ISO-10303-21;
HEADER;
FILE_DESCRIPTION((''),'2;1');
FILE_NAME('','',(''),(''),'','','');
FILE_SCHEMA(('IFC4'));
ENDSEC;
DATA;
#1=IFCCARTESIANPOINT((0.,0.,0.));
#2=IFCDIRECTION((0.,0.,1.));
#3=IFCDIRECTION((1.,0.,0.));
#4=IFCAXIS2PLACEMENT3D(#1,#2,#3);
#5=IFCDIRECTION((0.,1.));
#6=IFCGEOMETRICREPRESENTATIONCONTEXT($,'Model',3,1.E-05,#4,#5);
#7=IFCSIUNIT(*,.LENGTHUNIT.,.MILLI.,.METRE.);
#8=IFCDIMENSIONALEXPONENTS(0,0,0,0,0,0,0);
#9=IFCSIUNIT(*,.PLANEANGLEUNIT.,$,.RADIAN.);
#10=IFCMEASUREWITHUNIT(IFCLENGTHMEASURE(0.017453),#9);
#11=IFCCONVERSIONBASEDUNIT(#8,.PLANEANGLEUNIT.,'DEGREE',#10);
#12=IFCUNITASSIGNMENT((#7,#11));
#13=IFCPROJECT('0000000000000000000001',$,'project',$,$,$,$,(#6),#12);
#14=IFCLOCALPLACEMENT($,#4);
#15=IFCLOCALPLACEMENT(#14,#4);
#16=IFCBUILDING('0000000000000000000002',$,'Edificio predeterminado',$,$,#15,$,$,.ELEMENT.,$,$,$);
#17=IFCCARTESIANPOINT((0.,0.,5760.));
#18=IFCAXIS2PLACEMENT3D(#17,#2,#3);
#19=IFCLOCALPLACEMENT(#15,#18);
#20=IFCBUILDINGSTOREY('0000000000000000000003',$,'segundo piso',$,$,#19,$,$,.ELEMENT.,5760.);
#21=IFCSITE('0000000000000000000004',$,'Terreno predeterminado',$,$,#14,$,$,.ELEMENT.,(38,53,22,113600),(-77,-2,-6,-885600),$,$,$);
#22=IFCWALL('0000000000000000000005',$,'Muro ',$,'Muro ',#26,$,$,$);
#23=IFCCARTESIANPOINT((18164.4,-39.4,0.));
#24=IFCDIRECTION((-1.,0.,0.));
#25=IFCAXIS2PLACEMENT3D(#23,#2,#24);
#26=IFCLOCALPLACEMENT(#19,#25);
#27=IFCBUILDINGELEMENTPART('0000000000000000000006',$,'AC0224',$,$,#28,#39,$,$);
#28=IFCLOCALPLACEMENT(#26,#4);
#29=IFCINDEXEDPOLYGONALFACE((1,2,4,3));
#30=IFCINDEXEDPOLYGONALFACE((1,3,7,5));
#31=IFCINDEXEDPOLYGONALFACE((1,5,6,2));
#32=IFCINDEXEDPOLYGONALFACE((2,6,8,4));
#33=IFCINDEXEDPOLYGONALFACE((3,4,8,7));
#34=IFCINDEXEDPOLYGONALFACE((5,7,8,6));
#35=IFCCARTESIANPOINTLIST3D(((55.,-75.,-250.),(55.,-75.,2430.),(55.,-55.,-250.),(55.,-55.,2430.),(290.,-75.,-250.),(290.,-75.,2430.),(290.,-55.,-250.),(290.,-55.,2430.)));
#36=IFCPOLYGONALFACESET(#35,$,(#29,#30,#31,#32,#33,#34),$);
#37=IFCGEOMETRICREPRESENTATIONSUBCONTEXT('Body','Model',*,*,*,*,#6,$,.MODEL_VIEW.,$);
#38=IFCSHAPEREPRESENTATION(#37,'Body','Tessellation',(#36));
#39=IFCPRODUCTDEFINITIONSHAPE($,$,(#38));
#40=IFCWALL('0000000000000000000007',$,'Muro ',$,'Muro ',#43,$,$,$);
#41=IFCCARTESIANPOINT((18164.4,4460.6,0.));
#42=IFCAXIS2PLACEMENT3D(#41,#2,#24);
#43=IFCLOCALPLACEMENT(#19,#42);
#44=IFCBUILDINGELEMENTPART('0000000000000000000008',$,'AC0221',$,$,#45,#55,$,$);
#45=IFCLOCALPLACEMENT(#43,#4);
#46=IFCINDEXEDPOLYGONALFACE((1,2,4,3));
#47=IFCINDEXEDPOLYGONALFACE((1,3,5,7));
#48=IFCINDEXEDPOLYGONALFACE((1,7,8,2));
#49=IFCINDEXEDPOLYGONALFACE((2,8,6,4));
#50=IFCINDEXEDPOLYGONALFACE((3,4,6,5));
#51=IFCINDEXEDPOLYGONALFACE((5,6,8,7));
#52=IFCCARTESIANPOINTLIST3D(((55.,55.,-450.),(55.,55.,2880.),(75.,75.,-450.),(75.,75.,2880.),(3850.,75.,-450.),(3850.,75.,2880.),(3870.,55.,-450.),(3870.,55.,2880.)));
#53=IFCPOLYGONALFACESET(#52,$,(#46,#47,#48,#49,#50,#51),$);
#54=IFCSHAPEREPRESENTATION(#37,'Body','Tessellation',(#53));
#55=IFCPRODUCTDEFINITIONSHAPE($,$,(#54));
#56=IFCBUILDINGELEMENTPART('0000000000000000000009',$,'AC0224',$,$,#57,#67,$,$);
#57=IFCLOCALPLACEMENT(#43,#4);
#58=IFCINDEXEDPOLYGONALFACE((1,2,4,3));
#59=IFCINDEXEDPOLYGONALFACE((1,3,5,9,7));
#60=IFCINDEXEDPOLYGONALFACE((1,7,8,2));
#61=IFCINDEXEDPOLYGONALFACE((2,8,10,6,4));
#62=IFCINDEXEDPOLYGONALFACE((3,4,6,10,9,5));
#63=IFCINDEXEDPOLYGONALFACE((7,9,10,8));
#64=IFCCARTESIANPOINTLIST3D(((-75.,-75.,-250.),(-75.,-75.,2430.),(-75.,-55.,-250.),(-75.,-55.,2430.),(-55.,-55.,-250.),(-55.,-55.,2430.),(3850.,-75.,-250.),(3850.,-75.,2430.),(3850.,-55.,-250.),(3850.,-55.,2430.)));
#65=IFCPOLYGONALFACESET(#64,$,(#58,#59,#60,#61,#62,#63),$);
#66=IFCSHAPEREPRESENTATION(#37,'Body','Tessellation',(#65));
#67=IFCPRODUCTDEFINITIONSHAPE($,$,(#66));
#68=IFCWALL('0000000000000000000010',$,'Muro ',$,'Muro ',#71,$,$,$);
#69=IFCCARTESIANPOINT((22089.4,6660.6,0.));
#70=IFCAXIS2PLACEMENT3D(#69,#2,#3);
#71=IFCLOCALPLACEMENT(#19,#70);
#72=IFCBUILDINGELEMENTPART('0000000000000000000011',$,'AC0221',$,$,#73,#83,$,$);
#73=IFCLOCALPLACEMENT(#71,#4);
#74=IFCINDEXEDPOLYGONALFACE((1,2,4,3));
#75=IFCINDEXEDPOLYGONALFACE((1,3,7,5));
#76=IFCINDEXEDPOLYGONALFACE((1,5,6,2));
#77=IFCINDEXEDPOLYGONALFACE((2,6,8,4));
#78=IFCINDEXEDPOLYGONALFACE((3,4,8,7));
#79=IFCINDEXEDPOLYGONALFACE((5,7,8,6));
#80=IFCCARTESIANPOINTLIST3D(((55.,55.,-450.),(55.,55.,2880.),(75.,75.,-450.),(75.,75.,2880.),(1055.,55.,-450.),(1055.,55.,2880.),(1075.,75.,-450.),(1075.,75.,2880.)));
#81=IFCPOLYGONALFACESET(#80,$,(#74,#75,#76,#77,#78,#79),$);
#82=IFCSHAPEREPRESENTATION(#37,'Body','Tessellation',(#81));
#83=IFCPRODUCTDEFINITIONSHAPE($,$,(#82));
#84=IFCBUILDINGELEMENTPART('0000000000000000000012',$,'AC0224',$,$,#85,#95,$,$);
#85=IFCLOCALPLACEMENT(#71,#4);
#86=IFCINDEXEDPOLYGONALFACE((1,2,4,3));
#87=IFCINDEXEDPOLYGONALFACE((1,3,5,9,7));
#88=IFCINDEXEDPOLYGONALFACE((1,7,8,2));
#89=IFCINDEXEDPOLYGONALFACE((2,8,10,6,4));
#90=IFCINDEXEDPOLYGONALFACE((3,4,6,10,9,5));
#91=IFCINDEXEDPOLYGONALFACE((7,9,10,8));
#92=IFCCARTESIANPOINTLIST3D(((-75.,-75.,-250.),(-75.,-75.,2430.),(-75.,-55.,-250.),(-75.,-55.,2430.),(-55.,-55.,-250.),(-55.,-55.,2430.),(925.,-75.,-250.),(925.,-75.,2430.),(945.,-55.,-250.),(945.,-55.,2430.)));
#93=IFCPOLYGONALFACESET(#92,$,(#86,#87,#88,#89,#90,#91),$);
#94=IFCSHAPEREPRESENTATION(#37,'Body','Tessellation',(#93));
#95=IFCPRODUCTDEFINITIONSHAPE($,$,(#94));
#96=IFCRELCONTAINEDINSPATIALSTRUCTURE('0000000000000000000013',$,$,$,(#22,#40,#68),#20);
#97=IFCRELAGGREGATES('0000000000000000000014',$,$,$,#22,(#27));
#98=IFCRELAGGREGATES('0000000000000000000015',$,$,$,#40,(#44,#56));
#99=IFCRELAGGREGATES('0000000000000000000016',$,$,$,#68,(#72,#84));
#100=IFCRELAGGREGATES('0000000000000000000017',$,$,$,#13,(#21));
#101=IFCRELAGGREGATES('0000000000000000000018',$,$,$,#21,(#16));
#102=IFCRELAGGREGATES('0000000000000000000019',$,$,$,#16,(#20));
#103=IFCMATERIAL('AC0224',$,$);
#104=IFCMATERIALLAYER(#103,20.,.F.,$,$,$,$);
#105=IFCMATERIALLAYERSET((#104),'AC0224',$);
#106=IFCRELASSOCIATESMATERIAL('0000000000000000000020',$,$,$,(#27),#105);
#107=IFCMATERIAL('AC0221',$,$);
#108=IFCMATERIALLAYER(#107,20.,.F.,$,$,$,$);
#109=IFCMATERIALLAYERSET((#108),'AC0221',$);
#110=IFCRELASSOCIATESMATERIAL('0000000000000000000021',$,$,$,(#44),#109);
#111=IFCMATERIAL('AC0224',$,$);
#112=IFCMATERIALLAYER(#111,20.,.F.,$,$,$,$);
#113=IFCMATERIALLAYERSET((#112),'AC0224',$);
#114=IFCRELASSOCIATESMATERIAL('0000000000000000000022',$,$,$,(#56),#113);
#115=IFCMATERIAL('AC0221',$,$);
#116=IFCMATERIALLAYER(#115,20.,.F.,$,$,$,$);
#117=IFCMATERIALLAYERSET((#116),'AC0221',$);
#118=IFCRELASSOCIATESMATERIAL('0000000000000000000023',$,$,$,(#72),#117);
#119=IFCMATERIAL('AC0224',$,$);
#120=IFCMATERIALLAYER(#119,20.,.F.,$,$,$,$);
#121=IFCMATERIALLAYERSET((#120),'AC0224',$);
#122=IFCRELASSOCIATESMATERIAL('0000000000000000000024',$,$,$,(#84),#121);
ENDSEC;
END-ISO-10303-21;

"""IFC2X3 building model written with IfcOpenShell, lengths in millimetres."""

from ifc_helpers import new_model, entity, si_unit, converted_unit, direction, frame, origin_with_axes, place, context, subcontext, project, spatial, polyline, outline, extrude, material, layer, layer_set, layer_usage, element, aggregate, save


model = new_model("IFC2X3")

# Units and contexts
model_context = context("Model", 3, precision=1e-05, world=origin_with_axes(), true_north=direction((0.0, 1.0)))
body_context = subcontext(model_context, "Body", "Model", "MODEL_VIEW")
ifc_project = project(units=[si_unit("LENGTHUNIT", "METRE", prefix="MILLI"), converted_unit("PLANEANGLEUNIT", "DEGREE", entity("IfcLengthMeasure", 0.017453), si_unit("PLANEANGLEUNIT", "RADIAN"), dimensions=[0, 0, 0, 0, 0, 0, 0])], contexts=[model_context])

# Site, building, storey
site_placement = place(None, origin_with_axes())
site = spatial("IfcSite", under=ifc_project, at=site_placement, Name="Terreno predeterminado", CompositionType="ELEMENT", RefLatitude=(38, 53, 22, 113600), RefLongitude=(-77, -2, -6, -885600))
building_placement = place(site_placement, origin_with_axes())
building = spatial("IfcBuilding", under=site, at=building_placement, Name="Edificio predeterminado", CompositionType="ELEMENT")
storey_placement = place(building_placement, frame((0.0, 0.0, 5760.0), z_axis=(0.0, 0.0, 1.0), x_axis=(1.0, 0.0, 0.0)))
storey = spatial("IfcBuildingStorey", under=building, at=storey_placement, Name="segundo piso", CompositionType="ELEMENT", Elevation=5760.0)

# Wall, building element part
wall_1_placement = place(storey_placement, frame((18164.4, -39.4, 0.0), z_axis=(0.0, 0.0, 1.0), x_axis=(-1.0, 0.0, 0.0)))
wall_1 = element("IfcWall", 1, at=wall_1_placement, inside=storey, Name="Muro ", ObjectType="Muro ")
ifc_material_1 = material(Name="AC0224")
ifc_layer_1 = layer(ifc_material_1, 20.0, ventilated=False)
ifc_layer_set_1 = layer_set([ifc_layer_1], Name="AC0224")
ifc_layer_usage_1 = layer_usage(ifc_layer_set_1, "AXIS2", "NEGATIVE", 55.0)
building_element_part_1_placement = place(wall_1_placement, origin_with_axes())
building_element_part_1 = element("IfcBuildingElementPart", 2, at=building_element_part_1_placement, material=ifc_layer_usage_1, Name="AC0224", context=body_context, shape_type="SweptSolid", body=[
    extrude(outline(polyline([(290.0, -55.0), (290.0, -75.0), (55.0, -75.0), (55.0, -55.0), (290.0, -55.0)])), frame((0.0, 0.0, -250.0), z_axis=(0.0, 0.0, 1.0), x_axis=(1.0, 0.0, 0.0)), (0.0, 0.0, 1.0), 2680.0),
])
aggregate(wall_1, [building_element_part_1])

# Walls, building element parts
wall_2_placement = place(storey_placement, frame((18164.4, 4460.6, 0.0), z_axis=(0.0, 0.0, 1.0), x_axis=(-1.0, 0.0, 0.0)))
wall_2 = element("IfcWall", 3, at=wall_2_placement, inside=storey, Name="Muro ", ObjectType="Muro ")
ifc_material_2 = material(Name="AC0221")
ifc_layer_2 = layer(ifc_material_2, 20.0, ventilated=False)
ifc_layer_set_2 = layer_set([ifc_layer_2], Name="AC0221")
ifc_layer_usage_2 = layer_usage(ifc_layer_set_2, "AXIS2", "NEGATIVE", -75.0)
building_element_part_2_placement = place(wall_2_placement, origin_with_axes())
building_element_part_2 = element("IfcBuildingElementPart", 4, at=building_element_part_2_placement, material=ifc_layer_usage_2, Name="AC0221", context=body_context, shape_type="SweptSolid", body=[
    extrude(outline(polyline([(3850.0, 75.0), (3870.0, 55.0), (55.0, 55.0), (75.0, 75.0), (3850.0, 75.0)])), frame((0.0, 0.0, -450.0), z_axis=(0.0, 0.0, 1.0), x_axis=(1.0, 0.0, 0.0)), (0.0, 0.0, 1.0), 3330.0),
])
ifc_material_3 = material(Name="AC0224")
ifc_layer_3 = layer(ifc_material_3, 20.0, ventilated=False)
ifc_layer_set_3 = layer_set([ifc_layer_3], Name="AC0224")
ifc_layer_usage_3 = layer_usage(ifc_layer_set_3, "AXIS2", "NEGATIVE", 55.0)
building_element_part_3_placement = place(wall_2_placement, origin_with_axes())
building_element_part_3 = element("IfcBuildingElementPart", 5, at=building_element_part_3_placement, material=ifc_layer_usage_3, Name="AC0224", context=body_context, shape_type="SweptSolid", body=[
    extrude(outline(polyline([(3850.0, -55.0), (3850.0, -75.0), (-75.0, -75.0), (-75.0, -55.0), (-55.0, -55.0), (3850.0, -55.0)])), frame((0.0, 0.0, -250.0), z_axis=(0.0, 0.0, 1.0), x_axis=(1.0, 0.0, 0.0)), (0.0, 0.0, 1.0), 2680.0),
])
aggregate(wall_2, [building_element_part_2, building_element_part_3])
wall_3_placement = place(storey_placement, frame((22089.4, 6660.6, 0.0), z_axis=(0.0, 0.0, 1.0), x_axis=(1.0, 0.0, 0.0)))
wall_3 = element("IfcWall", 6, at=wall_3_placement, inside=storey, Name="Muro ", ObjectType="Muro ")
ifc_material_4 = material(Name="AC0221")
ifc_layer_4 = layer(ifc_material_4, 20.0, ventilated=False)
ifc_layer_set_4 = layer_set([ifc_layer_4], Name="AC0221")
ifc_layer_usage_4 = layer_usage(ifc_layer_set_4, "AXIS2", "NEGATIVE", -75.0)
building_element_part_4_placement = place(wall_3_placement, origin_with_axes())
building_element_part_4 = element("IfcBuildingElementPart", 7, at=building_element_part_4_placement, material=ifc_layer_usage_4, Name="AC0221", context=body_context, shape_type="SweptSolid", body=[
    extrude(outline(polyline([(1075.0, 75.0), (1055.0, 55.0), (55.0, 55.0), (75.0, 75.0), (1075.0, 75.0)])), frame((0.0, 0.0, -450.0), z_axis=(0.0, 0.0, 1.0), x_axis=(1.0, 0.0, 0.0)), (0.0, 0.0, 1.0), 3330.0),
])
ifc_material_5 = material(Name="AC0224")
ifc_layer_5 = layer(ifc_material_5, 20.0, ventilated=False)
ifc_layer_set_5 = layer_set([ifc_layer_5], Name="AC0224")
ifc_layer_usage_5 = layer_usage(ifc_layer_set_5, "AXIS2", "NEGATIVE", 55.0)
building_element_part_5_placement = place(wall_3_placement, origin_with_axes())
building_element_part_5 = element("IfcBuildingElementPart", 8, at=building_element_part_5_placement, material=ifc_layer_usage_5, Name="AC0224", context=body_context, shape_type="SweptSolid", body=[
    extrude(outline(polyline([(945.0, -55.0), (925.0, -75.0), (-75.0, -75.0), (-75.0, -55.0), (-55.0, -55.0), (945.0, -55.0)])), frame((0.0, 0.0, -250.0), z_axis=(0.0, 0.0, 1.0), x_axis=(1.0, 0.0, 0.0)), (0.0, 0.0, 1.0), 2680.0),
])
aggregate(wall_3, [building_element_part_4, building_element_part_5])

save(model, "model.ifc")
